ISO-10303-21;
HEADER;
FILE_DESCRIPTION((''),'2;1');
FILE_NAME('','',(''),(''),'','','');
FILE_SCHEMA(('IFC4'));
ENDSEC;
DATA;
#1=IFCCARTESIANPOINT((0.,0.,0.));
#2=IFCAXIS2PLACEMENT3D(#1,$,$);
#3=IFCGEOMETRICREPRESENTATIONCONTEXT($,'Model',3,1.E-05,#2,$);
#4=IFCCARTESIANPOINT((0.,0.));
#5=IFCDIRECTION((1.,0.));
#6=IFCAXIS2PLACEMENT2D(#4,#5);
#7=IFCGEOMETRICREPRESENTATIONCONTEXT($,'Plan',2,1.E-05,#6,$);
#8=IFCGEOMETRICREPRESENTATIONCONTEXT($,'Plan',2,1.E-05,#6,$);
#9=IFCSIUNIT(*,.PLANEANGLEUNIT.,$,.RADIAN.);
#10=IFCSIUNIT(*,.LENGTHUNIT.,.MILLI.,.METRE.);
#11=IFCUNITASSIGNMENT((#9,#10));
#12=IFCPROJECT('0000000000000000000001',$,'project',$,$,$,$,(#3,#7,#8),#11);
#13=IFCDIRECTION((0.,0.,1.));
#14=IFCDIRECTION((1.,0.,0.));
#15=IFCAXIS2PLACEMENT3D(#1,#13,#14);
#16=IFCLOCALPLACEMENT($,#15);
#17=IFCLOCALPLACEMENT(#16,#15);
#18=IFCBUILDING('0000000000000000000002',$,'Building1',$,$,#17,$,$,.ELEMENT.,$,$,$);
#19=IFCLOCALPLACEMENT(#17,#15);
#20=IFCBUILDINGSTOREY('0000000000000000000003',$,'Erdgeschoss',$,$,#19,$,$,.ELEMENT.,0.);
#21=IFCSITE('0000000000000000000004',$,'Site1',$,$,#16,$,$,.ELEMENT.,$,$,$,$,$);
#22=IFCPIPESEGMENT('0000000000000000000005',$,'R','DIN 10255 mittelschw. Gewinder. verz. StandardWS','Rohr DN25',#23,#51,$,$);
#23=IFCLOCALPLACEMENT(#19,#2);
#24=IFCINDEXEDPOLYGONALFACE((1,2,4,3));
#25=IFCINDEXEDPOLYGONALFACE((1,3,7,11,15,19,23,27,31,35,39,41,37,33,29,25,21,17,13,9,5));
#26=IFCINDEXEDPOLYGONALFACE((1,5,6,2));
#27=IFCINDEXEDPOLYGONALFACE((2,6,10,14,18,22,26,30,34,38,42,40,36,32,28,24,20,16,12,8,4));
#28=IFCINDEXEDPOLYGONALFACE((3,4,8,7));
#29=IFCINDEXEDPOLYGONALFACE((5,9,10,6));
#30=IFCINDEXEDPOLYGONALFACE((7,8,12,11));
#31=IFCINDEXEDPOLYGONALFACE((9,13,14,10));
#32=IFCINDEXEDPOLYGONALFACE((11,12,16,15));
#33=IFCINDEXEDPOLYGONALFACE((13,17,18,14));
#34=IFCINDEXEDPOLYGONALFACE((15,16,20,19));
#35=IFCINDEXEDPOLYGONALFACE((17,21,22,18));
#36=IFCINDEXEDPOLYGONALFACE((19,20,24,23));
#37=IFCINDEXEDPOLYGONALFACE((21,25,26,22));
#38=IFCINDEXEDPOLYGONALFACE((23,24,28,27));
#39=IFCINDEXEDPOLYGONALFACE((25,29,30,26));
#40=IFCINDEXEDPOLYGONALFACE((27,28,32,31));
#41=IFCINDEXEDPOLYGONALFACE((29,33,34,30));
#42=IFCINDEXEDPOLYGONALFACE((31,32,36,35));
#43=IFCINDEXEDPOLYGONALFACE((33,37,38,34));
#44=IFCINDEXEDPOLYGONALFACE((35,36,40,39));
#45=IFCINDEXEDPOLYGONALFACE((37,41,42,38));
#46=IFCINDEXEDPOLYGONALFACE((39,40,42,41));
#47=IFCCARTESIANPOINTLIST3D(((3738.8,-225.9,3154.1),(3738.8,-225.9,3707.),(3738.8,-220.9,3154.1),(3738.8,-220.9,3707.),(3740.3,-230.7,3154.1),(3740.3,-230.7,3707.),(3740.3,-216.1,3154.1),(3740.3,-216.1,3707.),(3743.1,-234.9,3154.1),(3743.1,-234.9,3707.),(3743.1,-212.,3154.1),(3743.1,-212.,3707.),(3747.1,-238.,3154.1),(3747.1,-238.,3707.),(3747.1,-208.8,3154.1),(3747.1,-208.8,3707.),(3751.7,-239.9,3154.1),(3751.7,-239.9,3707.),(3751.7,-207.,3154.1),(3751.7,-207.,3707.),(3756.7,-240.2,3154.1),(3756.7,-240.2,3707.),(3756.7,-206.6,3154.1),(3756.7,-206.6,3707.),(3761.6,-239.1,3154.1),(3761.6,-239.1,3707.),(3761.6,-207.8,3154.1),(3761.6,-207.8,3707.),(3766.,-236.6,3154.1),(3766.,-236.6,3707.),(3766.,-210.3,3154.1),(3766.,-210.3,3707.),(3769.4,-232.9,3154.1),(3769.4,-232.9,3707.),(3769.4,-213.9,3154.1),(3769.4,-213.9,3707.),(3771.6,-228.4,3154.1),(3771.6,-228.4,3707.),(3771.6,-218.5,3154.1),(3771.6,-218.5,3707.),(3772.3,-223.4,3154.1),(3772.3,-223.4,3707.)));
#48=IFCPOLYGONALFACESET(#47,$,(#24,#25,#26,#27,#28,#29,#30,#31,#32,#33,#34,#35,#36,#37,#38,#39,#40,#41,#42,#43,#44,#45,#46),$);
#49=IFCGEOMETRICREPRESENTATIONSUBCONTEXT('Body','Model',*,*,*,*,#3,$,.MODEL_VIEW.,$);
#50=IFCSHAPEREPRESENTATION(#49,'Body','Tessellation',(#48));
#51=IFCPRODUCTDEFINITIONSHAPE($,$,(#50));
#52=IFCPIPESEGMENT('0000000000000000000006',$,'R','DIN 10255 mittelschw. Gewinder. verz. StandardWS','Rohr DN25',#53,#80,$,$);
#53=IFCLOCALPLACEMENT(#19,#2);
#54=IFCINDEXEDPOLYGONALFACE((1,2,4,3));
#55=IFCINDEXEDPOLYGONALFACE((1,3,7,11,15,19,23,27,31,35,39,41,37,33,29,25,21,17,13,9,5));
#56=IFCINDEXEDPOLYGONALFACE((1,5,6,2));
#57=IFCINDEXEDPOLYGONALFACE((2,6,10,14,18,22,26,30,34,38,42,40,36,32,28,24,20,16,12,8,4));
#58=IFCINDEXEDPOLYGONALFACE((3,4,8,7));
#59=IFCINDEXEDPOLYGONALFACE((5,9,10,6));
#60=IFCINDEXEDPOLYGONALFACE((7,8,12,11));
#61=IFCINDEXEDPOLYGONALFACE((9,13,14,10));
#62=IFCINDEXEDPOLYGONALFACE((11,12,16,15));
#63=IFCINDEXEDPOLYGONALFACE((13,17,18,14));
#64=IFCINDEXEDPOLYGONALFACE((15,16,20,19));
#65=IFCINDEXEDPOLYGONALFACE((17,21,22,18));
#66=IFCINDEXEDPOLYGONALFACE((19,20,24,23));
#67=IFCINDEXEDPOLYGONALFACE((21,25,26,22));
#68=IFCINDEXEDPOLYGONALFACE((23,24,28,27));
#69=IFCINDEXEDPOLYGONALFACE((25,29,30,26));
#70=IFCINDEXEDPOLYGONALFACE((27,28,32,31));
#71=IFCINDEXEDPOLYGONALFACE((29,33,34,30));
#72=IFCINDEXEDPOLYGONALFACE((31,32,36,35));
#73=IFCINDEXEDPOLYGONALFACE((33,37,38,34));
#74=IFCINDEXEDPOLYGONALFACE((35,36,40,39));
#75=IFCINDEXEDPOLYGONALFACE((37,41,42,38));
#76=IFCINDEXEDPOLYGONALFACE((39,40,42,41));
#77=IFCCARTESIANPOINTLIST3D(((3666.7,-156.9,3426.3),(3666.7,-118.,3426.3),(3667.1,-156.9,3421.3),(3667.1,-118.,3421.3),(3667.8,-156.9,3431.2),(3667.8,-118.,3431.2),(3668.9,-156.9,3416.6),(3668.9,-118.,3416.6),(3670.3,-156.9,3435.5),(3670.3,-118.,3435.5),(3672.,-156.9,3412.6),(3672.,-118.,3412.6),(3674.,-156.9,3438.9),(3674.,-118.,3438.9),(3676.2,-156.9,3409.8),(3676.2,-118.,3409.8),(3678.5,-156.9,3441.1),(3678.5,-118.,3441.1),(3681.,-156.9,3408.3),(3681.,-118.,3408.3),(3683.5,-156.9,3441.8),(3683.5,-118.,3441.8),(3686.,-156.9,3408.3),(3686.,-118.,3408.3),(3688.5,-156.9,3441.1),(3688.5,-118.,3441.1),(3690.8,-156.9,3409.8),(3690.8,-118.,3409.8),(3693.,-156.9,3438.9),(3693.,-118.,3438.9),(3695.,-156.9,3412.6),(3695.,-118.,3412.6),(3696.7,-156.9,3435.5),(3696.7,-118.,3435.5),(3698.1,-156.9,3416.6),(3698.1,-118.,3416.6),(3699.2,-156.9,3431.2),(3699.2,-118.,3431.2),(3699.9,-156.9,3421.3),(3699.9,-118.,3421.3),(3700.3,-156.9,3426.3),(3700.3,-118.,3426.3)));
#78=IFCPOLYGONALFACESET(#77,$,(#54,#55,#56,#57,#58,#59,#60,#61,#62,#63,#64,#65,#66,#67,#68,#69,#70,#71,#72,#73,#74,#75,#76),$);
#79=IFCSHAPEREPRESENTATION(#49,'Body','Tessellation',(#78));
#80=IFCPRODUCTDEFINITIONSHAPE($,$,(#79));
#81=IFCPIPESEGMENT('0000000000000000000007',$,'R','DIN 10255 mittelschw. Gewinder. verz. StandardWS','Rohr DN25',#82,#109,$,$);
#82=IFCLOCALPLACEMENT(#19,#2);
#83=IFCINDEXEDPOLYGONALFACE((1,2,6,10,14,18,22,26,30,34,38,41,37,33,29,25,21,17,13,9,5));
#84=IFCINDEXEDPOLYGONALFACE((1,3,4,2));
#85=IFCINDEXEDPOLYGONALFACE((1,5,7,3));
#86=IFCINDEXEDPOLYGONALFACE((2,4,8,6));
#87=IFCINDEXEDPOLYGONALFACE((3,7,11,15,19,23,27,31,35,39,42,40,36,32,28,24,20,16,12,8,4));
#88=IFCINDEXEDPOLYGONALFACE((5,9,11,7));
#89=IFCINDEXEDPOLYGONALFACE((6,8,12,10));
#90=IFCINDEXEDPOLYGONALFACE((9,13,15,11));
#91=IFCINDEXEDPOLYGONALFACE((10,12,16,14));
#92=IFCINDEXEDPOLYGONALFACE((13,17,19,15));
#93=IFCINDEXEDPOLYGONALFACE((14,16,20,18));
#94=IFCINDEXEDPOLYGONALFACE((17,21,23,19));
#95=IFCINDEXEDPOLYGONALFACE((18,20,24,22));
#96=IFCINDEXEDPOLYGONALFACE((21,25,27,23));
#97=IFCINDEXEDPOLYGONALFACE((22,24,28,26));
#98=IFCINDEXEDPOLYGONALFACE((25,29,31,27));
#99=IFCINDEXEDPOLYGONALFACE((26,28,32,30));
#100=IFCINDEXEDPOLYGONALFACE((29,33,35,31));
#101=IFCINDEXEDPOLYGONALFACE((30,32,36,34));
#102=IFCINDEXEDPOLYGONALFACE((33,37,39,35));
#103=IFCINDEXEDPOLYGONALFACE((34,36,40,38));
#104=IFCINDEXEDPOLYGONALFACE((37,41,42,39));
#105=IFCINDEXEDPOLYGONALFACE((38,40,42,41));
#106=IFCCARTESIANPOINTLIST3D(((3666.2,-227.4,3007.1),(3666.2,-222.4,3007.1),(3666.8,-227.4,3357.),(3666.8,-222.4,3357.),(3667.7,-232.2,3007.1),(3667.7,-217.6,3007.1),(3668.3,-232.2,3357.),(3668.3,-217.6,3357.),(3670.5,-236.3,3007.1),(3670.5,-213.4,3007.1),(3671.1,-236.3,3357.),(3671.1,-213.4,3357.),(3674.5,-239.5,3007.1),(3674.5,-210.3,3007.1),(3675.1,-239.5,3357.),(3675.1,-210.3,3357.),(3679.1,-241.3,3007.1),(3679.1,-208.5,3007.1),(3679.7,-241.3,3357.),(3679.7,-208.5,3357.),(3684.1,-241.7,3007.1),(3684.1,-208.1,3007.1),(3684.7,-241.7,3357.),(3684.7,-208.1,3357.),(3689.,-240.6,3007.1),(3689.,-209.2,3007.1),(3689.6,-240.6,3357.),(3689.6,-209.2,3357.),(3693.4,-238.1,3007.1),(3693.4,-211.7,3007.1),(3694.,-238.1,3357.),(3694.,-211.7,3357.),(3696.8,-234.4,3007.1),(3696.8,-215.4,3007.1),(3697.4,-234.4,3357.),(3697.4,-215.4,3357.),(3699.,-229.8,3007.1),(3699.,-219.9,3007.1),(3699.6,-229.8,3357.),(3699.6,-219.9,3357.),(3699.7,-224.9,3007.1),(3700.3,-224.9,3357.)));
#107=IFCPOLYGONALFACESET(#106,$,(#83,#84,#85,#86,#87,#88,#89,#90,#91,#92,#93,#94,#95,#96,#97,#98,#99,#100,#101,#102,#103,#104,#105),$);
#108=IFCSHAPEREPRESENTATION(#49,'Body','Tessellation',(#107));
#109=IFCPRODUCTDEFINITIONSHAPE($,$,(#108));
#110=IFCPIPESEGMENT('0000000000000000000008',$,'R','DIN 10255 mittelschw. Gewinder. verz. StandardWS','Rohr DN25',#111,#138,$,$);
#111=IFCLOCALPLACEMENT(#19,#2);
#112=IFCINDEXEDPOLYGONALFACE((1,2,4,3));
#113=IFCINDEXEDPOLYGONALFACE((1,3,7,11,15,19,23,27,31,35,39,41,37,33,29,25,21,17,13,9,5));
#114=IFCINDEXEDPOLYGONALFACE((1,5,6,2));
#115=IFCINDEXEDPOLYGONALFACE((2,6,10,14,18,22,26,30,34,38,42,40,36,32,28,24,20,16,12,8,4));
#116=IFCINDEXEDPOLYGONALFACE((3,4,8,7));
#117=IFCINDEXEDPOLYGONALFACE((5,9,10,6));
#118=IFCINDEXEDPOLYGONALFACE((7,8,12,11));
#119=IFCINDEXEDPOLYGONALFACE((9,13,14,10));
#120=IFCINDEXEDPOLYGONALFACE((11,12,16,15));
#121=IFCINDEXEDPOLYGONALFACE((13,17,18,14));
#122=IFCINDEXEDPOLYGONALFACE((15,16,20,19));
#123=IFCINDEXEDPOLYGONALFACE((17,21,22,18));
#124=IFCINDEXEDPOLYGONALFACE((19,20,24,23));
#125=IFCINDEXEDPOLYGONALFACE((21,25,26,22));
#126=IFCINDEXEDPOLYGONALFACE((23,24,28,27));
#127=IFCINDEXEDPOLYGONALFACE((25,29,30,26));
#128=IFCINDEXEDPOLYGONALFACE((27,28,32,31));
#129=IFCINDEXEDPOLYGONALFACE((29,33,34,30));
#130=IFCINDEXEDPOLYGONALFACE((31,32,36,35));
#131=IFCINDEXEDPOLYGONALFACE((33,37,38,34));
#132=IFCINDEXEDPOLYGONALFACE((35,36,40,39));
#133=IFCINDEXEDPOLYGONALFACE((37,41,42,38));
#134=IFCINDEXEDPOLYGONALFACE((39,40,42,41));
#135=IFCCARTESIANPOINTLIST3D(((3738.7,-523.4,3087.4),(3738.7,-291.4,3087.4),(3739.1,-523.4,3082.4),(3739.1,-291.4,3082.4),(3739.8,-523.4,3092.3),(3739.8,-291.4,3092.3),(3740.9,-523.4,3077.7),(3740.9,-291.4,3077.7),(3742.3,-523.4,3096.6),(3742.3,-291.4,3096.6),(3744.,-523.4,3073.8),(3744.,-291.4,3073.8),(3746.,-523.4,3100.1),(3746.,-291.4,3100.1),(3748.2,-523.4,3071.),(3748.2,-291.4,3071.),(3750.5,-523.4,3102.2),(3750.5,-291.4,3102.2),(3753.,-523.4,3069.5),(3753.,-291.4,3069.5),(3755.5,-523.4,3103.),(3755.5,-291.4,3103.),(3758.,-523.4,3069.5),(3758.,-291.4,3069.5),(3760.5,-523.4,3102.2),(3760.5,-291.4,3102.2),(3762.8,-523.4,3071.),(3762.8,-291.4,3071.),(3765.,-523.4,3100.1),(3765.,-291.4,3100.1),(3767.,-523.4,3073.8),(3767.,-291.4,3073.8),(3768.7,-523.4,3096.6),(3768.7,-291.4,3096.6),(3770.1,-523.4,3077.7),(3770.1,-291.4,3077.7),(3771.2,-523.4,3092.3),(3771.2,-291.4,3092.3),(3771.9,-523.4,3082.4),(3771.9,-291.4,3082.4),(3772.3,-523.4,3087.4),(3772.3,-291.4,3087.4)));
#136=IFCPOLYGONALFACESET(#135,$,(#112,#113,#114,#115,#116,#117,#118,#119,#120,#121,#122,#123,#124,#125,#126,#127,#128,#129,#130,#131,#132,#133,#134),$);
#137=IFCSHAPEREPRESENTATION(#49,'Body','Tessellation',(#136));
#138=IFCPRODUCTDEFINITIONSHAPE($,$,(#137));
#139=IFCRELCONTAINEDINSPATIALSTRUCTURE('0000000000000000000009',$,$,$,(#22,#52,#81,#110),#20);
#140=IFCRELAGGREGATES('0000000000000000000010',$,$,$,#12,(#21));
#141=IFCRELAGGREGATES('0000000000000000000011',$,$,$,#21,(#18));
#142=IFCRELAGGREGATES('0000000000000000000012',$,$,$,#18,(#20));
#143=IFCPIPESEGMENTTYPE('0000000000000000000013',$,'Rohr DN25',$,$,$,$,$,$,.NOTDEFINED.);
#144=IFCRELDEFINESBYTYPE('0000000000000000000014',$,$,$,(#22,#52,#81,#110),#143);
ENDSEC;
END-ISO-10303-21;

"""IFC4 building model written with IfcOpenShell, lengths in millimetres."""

from ifc_helpers import new_model, si_unit, frame, origin, origin_with_axes, origin_2d_with_axis, place, context, subcontext, project, spatial, circle, extrude, type_object, element, save


model = new_model("IFC4")

# Units and contexts
model_context = context("Model", 3, precision=1e-05, world=origin())
plan_context_1 = context("Plan", 2, precision=1e-05, world=origin_2d_with_axis())
plan_context_2 = context("Plan", 2, precision=1e-05, world=origin_2d_with_axis())
body_context = subcontext(model_context, "Body", "Model", "MODEL_VIEW")
ifc_project = project(units=[si_unit("PLANEANGLEUNIT", "RADIAN"), si_unit("LENGTHUNIT", "METRE", prefix="MILLI")], contexts=[model_context, plan_context_1, plan_context_2])

# Site, building, storey
site_placement = place(None, origin_with_axes())
site = spatial("IfcSite", under=ifc_project, at=site_placement, Name="Site1", CompositionType="ELEMENT")
building_placement = place(site_placement, origin_with_axes())
building = spatial("IfcBuilding", under=site, at=building_placement, Name="Building1", CompositionType="ELEMENT")
storey_placement = place(building_placement, origin_with_axes())
storey = spatial("IfcBuildingStorey", under=building, at=storey_placement, Name="Erdgeschoss", CompositionType="ELEMENT", Elevation=0.0)

# Pipe segments
pipe_segment_type_1 = type_object("IfcPipeSegmentType", Name="Rohr DN25", PredefinedType="NOTDEFINED")
pipe_segment_1_placement = place(storey_placement, frame((3755.5, -223.3, 3430.6), z_axis=(0.0, 0.0, 1.0), x_axis=(1.0, 0.0, 0.0)))
element("IfcPipeSegment", 1, at=pipe_segment_1_placement, inside=storey, type_object=pipe_segment_type_1, Name="R", Description="DIN 10255 mittelschw. Gewinder. verz. StandardWS", ObjectType="Rohr DN25", context=body_context, shape_type="SolidModel", body=[
    extrude(circle(Radius=16.9, at=origin_2d_with_axis()), frame((0.0, -0.2, 276.4), z_axis=(0.0, 0.0, -1.0), x_axis=(1.0, 0.0, 0.0)), (0.0, 0.0, 1.0), 552.9),
])
pipe_segment_2_placement = place(storey_placement, frame((3683.6, -137.4, 3425.0), z_axis=(0.0, 0.0, 1.0), x_axis=(1.0, 0.0, 0.0)))
element("IfcPipeSegment", 2, at=pipe_segment_2_placement, inside=storey, type_object=pipe_segment_type_1, Name="R", Description="DIN 10255 mittelschw. Gewinder. verz. StandardWS", ObjectType="Rohr DN25", context=body_context, shape_type="SolidModel", body=[
    extrude(circle(Radius=16.9, at=origin_2d_with_axis()), frame((-0.2, 19.4, 0.0), z_axis=(0.0, -1.0, 0.0), x_axis=(0.0, 0.0, 1.0)), (0.0, 0.0, 1.0), 38.9),
])
pipe_segment_3_placement = place(storey_placement, frame((3683.2, -225.0, 3182.1), z_axis=(0.0, 0.0, 1.0), x_axis=(1.0, 0.0, 0.0)))
element("IfcPipeSegment", 3, at=pipe_segment_3_placement, inside=storey, type_object=pipe_segment_type_1, Name="R", Description="DIN 10255 mittelschw. Gewinder. verz. StandardWS", ObjectType="Rohr DN25", context=body_context, shape_type="SolidModel", body=[
    extrude(circle(Radius=16.9, at=origin_2d_with_axis()), frame((0.3, 0.2, 174.9), z_axis=(-0.00173, 0.0, -0.999999), x_axis=(1.0, 0.0, 0.0)), (0.0, 0.0, 1.0), 349.9),
])
pipe_segment_4_placement = place(storey_placement, frame((3755.3, -407.4, 3086.1), z_axis=(0.0, 0.0, 1.0), x_axis=(1.0, 0.0, 0.0)))
element("IfcPipeSegment", 4, at=pipe_segment_4_placement, inside=storey, type_object=pipe_segment_type_1, Name="R", Description="DIN 10255 mittelschw. Gewinder. verz. StandardWS", ObjectType="Rohr DN25", context=body_context, shape_type="SolidModel", body=[
    extrude(circle(Radius=16.9, at=origin_2d_with_axis()), frame((0.2, -116.0, 0.0), z_axis=(0.0, 1.0, 0.0), x_axis=(0.0, 0.0, 1.0)), (0.0, 0.0, 1.0), 232.0),
])

save(model, "model.ifc")
